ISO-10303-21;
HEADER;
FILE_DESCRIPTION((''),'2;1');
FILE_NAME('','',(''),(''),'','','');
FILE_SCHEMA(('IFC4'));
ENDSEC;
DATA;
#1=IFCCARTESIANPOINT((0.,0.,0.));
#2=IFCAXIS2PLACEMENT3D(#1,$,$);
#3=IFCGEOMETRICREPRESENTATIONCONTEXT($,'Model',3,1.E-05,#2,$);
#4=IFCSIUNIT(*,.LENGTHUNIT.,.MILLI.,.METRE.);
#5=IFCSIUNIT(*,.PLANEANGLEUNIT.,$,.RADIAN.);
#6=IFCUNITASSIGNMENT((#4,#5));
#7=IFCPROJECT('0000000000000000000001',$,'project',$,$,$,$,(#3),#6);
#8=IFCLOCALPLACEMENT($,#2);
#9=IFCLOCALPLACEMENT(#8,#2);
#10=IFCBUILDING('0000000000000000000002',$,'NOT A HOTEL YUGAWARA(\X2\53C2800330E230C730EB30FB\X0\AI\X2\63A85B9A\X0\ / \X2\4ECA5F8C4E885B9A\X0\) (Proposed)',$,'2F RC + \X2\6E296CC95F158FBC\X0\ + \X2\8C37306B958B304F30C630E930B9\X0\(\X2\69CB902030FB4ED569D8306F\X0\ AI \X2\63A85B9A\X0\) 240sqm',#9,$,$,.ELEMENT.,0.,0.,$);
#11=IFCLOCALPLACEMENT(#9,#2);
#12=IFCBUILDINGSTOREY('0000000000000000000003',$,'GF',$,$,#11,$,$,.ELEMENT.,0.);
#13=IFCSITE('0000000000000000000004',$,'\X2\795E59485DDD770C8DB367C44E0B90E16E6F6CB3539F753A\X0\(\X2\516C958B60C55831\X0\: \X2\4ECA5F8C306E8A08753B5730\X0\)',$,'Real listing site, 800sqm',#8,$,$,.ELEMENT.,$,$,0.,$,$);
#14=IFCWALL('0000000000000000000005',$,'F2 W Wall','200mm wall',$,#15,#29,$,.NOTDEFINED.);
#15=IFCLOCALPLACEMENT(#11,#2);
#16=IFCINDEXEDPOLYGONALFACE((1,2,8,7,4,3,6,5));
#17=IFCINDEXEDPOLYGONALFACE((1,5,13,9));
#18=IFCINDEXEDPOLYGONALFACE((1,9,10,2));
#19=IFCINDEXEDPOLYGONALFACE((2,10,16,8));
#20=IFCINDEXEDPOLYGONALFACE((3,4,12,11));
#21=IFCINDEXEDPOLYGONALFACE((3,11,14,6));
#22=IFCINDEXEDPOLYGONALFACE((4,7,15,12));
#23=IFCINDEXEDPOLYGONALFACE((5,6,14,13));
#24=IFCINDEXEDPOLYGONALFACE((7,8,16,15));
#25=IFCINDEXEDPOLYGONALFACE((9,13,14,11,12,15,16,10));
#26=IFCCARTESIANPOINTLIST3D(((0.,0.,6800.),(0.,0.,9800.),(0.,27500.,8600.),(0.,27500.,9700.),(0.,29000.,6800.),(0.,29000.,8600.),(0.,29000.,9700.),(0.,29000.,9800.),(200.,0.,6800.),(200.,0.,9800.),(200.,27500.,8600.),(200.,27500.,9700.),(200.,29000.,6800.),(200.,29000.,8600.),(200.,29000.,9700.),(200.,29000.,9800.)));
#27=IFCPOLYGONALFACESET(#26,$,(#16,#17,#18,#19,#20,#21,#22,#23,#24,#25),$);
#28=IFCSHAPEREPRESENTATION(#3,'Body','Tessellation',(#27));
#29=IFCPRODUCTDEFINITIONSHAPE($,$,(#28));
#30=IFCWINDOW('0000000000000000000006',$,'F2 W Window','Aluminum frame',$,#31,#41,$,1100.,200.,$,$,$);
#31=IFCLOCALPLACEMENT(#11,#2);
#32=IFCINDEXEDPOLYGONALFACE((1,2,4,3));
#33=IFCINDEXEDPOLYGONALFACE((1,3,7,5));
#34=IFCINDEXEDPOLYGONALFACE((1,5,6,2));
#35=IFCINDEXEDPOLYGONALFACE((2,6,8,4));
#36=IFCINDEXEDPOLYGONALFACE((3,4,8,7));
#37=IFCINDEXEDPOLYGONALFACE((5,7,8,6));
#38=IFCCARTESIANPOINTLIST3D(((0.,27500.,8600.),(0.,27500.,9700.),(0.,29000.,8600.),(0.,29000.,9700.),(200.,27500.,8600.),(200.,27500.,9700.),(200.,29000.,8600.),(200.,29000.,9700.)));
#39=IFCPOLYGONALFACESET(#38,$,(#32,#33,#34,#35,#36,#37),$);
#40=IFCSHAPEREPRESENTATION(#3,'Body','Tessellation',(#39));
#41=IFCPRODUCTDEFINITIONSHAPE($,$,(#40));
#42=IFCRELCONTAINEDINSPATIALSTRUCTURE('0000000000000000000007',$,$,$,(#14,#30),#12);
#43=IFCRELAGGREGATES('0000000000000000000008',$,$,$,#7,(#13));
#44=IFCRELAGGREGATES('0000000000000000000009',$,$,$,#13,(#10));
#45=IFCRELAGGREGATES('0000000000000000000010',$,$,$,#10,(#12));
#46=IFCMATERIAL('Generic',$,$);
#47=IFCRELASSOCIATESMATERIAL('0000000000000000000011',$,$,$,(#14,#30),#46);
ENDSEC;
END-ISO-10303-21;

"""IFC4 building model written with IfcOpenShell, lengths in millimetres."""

from ifc_helpers import new_model, si_unit, frame, frame_2d, origin, place, context, project, spatial, rectangle, extrude, material, element, fill, save


model = new_model("IFC4")

# Units and contexts
model_context = context("Model", 3, precision=1e-05, world=origin())
ifc_project = project(units=[si_unit("LENGTHUNIT", "METRE", prefix="MILLI"), si_unit("PLANEANGLEUNIT", "RADIAN")], contexts=[model_context])

# Site, building, storey
site_placement = place(None, origin())
site = spatial("IfcSite", under=ifc_project, at=site_placement, Name="神奈川県足柄下郡湯河原町(公開情報: 今後の計画地)", ObjectType="Real listing site, 800sqm", CompositionType="ELEMENT", RefElevation=0.0)
building_placement = place(site_placement, origin())
building = spatial("IfcBuilding", under=site, at=building_placement, Name="NOT A HOTEL YUGAWARA(参考モデル・AI推定 / 今後予定) (Proposed)", ObjectType="2F RC + 温泉引込 + 谷に開くテラス(構造・仕様は AI 推定) 240sqm", CompositionType="ELEMENT", ElevationOfRefHeight=0.0, ElevationOfTerrain=0.0)
storey_placement = place(building_placement, origin())
storey = spatial("IfcBuildingStorey", under=building, at=storey_placement, Name="GF", CompositionType="ELEMENT", Elevation=0.0)

# Shared definitions
ifc_material_1 = material(Name="Generic")

# Wall, opening, window
wall_1_placement = place(storey_placement, frame((0.0, 0.0, 3400.0)))
wall_1 = element("IfcWall", 1, at=wall_1_placement, inside=storey, material=ifc_material_1, Name="F2 W Wall", Description="200mm wall", PredefinedType="NOTDEFINED", context=model_context, shape_type="SweptSolid", body=[
    extrude(rectangle(XDim=200.0, YDim=29000.0, at=frame_2d((100.0, 14500.0))), frame((0.0, 0.0, 3400.0)), (0.0, 0.0, 1.0), 3000.0),
])
opening_1_placement = place(storey_placement, frame((0.0, 13750.0, 4300.0)))
opening_1 = element("IfcOpeningElement", 2, at=opening_1_placement, cuts=wall_1, PredefinedType="NOTDEFINED", context=model_context, shape_type="SweptSolid", body=[
    extrude(rectangle(XDim=200.0, YDim=1500.0, at=frame_2d((100.0, 750.0))), frame((0.0, 13750.0, 4300.0)), (0.0, 0.0, 1.0), 1100.0),
])
window_1_placement = place(storey_placement, frame((0.0, 13750.0, 4300.0)))
window_1 = element("IfcWindow", 3, at=window_1_placement, inside=storey, material=ifc_material_1, Name="F2 W Window", Description="Aluminum frame", OverallHeight=1100.0, OverallWidth=200.0, context=model_context, shape_type="SweptSolid", body=[
    extrude(rectangle(XDim=200.0, YDim=1500.0, at=frame_2d((100.0, 750.0))), frame((0.0, 13750.0, 4300.0)), (0.0, 0.0, 1.0), 1100.0),
])
fill(opening_1, window_1)

save(model, "model.ifc")
